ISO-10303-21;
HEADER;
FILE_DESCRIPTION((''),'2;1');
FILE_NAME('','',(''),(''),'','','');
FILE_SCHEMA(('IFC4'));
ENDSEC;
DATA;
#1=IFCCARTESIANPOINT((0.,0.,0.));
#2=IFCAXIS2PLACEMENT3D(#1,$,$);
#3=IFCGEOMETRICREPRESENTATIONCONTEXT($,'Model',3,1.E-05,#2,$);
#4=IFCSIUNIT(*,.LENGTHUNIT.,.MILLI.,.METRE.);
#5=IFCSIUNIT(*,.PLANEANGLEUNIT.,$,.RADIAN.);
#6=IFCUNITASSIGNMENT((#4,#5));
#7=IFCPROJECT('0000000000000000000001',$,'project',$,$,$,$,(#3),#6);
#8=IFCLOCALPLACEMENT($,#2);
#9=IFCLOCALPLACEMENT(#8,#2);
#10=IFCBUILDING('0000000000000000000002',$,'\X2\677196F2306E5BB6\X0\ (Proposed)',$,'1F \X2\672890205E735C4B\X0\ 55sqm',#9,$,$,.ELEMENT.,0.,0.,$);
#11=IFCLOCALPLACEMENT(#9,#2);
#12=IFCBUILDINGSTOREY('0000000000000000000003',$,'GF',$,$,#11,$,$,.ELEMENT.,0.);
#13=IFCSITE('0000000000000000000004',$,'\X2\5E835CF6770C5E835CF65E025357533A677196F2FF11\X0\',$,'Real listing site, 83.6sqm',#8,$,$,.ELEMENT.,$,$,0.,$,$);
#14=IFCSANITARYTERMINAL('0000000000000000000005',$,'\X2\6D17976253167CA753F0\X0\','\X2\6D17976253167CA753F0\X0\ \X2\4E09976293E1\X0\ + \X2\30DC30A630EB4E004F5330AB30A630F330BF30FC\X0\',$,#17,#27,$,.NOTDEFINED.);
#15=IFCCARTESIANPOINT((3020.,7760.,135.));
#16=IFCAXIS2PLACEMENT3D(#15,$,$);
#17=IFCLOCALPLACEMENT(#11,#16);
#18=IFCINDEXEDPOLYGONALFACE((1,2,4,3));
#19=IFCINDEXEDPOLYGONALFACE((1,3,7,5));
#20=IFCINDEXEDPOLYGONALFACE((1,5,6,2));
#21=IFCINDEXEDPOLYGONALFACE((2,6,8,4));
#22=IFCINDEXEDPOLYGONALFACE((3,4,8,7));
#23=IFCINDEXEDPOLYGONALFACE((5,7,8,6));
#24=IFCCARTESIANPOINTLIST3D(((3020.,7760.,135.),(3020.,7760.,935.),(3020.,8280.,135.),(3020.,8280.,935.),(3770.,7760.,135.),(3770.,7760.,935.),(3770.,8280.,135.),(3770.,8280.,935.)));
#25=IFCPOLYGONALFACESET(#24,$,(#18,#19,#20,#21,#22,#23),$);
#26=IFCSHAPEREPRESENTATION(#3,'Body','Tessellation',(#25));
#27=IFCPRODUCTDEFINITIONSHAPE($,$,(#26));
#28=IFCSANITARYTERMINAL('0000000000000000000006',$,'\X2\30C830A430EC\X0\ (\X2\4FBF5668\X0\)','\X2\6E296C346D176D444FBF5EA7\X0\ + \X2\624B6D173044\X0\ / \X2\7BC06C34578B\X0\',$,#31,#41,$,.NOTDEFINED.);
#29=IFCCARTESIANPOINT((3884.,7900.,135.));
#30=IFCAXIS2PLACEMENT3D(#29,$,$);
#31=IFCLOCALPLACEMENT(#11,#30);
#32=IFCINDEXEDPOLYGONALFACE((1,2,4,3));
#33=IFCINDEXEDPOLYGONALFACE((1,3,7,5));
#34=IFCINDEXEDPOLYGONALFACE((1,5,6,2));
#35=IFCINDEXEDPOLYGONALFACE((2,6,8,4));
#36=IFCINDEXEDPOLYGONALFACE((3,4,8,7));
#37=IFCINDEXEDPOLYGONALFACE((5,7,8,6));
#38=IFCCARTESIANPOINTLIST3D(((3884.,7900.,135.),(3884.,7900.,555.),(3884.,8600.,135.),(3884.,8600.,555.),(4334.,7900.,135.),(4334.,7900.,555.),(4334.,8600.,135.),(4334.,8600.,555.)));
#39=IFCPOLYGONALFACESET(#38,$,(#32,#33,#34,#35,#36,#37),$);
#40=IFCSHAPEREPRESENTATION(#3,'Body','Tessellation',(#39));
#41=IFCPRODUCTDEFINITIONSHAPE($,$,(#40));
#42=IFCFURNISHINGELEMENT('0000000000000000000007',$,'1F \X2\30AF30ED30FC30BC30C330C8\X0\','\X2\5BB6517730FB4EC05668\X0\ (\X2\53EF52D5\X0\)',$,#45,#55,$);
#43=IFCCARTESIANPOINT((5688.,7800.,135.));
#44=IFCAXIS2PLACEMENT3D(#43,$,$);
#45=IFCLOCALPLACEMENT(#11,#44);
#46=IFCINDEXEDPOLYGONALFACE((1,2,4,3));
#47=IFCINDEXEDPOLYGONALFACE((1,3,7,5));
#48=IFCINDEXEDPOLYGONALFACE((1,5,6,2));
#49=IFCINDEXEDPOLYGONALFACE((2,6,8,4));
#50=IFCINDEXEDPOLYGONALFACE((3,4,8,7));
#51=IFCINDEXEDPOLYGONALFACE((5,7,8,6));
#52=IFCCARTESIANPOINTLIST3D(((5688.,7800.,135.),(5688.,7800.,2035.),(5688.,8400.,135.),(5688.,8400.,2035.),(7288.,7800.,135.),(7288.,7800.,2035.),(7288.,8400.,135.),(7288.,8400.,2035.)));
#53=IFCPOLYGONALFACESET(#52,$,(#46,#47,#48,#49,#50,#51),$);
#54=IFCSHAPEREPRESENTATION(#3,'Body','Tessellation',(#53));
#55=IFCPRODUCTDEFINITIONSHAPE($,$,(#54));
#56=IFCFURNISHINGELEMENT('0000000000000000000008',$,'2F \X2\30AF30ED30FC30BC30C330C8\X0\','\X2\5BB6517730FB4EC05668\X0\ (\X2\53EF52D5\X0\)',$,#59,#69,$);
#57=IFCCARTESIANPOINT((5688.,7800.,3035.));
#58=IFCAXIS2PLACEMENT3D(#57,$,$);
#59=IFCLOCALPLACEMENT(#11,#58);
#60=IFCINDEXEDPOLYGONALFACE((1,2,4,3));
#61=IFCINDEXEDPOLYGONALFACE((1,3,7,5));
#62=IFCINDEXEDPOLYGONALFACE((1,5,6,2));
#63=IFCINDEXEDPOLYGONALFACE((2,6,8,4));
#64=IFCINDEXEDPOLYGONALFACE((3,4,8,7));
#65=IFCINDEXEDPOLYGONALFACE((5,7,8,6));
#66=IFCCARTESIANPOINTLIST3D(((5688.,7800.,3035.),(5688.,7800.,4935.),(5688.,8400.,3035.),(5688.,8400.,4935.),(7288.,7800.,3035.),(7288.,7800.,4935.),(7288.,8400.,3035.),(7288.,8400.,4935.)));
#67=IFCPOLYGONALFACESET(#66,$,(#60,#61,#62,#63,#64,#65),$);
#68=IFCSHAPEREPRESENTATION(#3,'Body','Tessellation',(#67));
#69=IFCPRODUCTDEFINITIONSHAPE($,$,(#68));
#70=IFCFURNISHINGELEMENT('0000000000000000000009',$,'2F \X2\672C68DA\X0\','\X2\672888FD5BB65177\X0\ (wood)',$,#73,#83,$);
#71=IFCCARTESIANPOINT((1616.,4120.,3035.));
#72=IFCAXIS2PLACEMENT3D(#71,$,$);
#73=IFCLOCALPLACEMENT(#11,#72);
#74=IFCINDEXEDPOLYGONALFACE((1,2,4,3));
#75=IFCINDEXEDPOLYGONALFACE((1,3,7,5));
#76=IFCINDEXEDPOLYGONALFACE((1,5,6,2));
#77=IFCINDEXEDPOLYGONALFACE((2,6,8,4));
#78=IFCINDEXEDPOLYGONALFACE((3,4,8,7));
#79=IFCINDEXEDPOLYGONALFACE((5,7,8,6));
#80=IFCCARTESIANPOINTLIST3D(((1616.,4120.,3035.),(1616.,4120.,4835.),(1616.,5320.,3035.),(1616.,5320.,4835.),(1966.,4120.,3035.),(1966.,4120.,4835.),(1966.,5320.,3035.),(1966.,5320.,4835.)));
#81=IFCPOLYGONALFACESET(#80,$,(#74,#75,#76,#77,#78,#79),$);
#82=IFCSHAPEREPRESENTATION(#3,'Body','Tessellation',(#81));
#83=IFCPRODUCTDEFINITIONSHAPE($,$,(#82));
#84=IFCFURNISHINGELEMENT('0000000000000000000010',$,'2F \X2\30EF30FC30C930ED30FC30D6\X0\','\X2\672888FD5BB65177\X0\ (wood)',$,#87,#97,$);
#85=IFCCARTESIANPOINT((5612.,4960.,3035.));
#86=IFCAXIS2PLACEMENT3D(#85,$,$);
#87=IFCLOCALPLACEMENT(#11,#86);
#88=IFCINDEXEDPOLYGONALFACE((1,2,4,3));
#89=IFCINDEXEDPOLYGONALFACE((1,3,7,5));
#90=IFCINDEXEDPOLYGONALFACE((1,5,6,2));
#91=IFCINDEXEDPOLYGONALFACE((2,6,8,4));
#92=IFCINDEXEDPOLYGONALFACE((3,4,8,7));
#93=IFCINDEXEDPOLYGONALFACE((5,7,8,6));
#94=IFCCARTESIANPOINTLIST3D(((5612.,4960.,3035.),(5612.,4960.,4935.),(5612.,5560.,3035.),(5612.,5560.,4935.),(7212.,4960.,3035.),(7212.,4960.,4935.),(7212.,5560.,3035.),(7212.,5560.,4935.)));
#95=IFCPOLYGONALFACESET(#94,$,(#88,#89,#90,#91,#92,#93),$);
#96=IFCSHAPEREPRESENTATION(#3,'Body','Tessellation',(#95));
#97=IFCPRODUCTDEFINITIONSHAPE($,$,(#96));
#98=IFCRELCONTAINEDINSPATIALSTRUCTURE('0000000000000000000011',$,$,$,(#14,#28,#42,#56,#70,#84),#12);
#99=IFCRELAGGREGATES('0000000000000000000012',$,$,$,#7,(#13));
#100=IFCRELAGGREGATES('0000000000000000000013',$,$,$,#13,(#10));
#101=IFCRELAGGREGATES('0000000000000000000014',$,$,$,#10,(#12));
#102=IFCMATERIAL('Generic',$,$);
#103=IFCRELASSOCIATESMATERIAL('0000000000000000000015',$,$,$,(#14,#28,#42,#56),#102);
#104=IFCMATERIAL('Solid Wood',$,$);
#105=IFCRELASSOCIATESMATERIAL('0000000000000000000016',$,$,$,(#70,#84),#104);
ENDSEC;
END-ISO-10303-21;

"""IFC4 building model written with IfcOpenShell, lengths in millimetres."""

from ifc_helpers import new_model, si_unit, frame, frame_2d, origin, place, context, project, spatial, rectangle, extrude, material, element, save


model = new_model("IFC4")

# Units and contexts
model_context = context("Model", 3, precision=1e-05, world=origin())
ifc_project = project(units=[si_unit("LENGTHUNIT", "METRE", prefix="MILLI"), si_unit("PLANEANGLEUNIT", "RADIAN")], contexts=[model_context])

# Site, building, storey
site_placement = place(None, origin())
site = spatial("IfcSite", under=ifc_project, at=site_placement, Name="広島県広島市南区東雲１", ObjectType="Real listing site, 83.6sqm", CompositionType="ELEMENT", RefElevation=0.0)
building_placement = place(site_placement, origin())
building = spatial("IfcBuilding", under=site, at=building_placement, Name="東雲の家 (Proposed)", ObjectType="1F 木造平屋 55sqm", CompositionType="ELEMENT", ElevationOfRefHeight=0.0, ElevationOfTerrain=0.0)
storey_placement = place(building_placement, origin())
storey = spatial("IfcBuildingStorey", under=building, at=storey_placement, Name="GF", CompositionType="ELEMENT", Elevation=0.0)

# Shared definitions
ifc_material_1 = material(Name="Solid Wood")

# Shared definitions
ifc_material_2 = material(Name="Generic")

# Sanitary terminals
sanitary_terminal_1_placement = place(storey_placement, frame((3020.0, 7760.0, 135.0)))
element("IfcSanitaryTerminal", 1, at=sanitary_terminal_1_placement, inside=storey, material=ifc_material_2, Name="洗面化粧台", Description="洗面化粧台 三面鏡 + ボウル一体カウンター", PredefinedType="NOTDEFINED", context=model_context, shape_type="SweptSolid", body=[
    extrude(rectangle(XDim=750.0, YDim=520.0, at=frame_2d((375.0, 260.0))), frame((3020.0, 7760.0, 135.0)), (0.0, 0.0, 1.0), 800.0),
])
sanitary_terminal_2_placement = place(storey_placement, frame((3884.0, 7900.0, 135.0)))
element("IfcSanitaryTerminal", 2, at=sanitary_terminal_2_placement, inside=storey, material=ifc_material_2, Name="トイレ (便器)", Description="温水洗浄便座 + 手洗い / 節水型", PredefinedType="NOTDEFINED", context=model_context, shape_type="SweptSolid", body=[
    extrude(rectangle(XDim=450.0, YDim=700.0, at=frame_2d((225.0, 350.0))), frame((3884.0, 7900.0, 135.0)), (0.0, 0.0, 1.0), 420.0),
])

# Furnishing elements
furnishing_1_placement = place(storey_placement, frame((5688.0, 7800.0, 135.0)))
element("IfcFurnishingElement", 3, at=furnishing_1_placement, inside=storey, material=ifc_material_2, Name="1F クローゼット", Description="家具・什器 (可動)", context=model_context, shape_type="SweptSolid", body=[
    extrude(rectangle(XDim=1600.0, YDim=600.0, at=frame_2d((800.0, 300.0))), frame((5688.0, 7800.0, 135.0)), (0.0, 0.0, 1.0), 1900.0),
])
furnishing_2_placement = place(storey_placement, frame((5688.0, 7800.0, 3035.0)))
element("IfcFurnishingElement", 4, at=furnishing_2_placement, inside=storey, material=ifc_material_2, Name="2F クローゼット", Description="家具・什器 (可動)", context=model_context, shape_type="SweptSolid", body=[
    extrude(rectangle(XDim=1600.0, YDim=600.0, at=frame_2d((800.0, 300.0))), frame((5688.0, 7800.0, 3035.0)), (0.0, 0.0, 1.0), 1900.0),
])
furnishing_3_placement = place(storey_placement, frame((1616.0, 4120.0, 3035.0)))
element("IfcFurnishingElement", 5, at=furnishing_3_placement, inside=storey, material=ifc_material_1, Name="2F 本棚", Description="木製家具 (wood)", context=model_context, shape_type="SweptSolid", body=[
    extrude(rectangle(XDim=350.0, YDim=1200.0, at=frame_2d((175.0, 600.0))), frame((1616.0, 4120.0, 3035.0)), (0.0, 0.0, 1.0), 1800.0),
])
furnishing_4_placement = place(storey_placement, frame((5612.0, 4960.0, 3035.0)))
element("IfcFurnishingElement", 6, at=furnishing_4_placement, inside=storey, material=ifc_material_1, Name="2F ワードローブ", Description="木製家具 (wood)", context=model_context, shape_type="SweptSolid", body=[
    extrude(rectangle(XDim=1600.0, YDim=600.0, at=frame_2d((800.0, 300.0))), frame((5612.0, 4960.0, 3035.0)), (0.0, 0.0, 1.0), 1900.0),
])

save(model, "model.ifc")
